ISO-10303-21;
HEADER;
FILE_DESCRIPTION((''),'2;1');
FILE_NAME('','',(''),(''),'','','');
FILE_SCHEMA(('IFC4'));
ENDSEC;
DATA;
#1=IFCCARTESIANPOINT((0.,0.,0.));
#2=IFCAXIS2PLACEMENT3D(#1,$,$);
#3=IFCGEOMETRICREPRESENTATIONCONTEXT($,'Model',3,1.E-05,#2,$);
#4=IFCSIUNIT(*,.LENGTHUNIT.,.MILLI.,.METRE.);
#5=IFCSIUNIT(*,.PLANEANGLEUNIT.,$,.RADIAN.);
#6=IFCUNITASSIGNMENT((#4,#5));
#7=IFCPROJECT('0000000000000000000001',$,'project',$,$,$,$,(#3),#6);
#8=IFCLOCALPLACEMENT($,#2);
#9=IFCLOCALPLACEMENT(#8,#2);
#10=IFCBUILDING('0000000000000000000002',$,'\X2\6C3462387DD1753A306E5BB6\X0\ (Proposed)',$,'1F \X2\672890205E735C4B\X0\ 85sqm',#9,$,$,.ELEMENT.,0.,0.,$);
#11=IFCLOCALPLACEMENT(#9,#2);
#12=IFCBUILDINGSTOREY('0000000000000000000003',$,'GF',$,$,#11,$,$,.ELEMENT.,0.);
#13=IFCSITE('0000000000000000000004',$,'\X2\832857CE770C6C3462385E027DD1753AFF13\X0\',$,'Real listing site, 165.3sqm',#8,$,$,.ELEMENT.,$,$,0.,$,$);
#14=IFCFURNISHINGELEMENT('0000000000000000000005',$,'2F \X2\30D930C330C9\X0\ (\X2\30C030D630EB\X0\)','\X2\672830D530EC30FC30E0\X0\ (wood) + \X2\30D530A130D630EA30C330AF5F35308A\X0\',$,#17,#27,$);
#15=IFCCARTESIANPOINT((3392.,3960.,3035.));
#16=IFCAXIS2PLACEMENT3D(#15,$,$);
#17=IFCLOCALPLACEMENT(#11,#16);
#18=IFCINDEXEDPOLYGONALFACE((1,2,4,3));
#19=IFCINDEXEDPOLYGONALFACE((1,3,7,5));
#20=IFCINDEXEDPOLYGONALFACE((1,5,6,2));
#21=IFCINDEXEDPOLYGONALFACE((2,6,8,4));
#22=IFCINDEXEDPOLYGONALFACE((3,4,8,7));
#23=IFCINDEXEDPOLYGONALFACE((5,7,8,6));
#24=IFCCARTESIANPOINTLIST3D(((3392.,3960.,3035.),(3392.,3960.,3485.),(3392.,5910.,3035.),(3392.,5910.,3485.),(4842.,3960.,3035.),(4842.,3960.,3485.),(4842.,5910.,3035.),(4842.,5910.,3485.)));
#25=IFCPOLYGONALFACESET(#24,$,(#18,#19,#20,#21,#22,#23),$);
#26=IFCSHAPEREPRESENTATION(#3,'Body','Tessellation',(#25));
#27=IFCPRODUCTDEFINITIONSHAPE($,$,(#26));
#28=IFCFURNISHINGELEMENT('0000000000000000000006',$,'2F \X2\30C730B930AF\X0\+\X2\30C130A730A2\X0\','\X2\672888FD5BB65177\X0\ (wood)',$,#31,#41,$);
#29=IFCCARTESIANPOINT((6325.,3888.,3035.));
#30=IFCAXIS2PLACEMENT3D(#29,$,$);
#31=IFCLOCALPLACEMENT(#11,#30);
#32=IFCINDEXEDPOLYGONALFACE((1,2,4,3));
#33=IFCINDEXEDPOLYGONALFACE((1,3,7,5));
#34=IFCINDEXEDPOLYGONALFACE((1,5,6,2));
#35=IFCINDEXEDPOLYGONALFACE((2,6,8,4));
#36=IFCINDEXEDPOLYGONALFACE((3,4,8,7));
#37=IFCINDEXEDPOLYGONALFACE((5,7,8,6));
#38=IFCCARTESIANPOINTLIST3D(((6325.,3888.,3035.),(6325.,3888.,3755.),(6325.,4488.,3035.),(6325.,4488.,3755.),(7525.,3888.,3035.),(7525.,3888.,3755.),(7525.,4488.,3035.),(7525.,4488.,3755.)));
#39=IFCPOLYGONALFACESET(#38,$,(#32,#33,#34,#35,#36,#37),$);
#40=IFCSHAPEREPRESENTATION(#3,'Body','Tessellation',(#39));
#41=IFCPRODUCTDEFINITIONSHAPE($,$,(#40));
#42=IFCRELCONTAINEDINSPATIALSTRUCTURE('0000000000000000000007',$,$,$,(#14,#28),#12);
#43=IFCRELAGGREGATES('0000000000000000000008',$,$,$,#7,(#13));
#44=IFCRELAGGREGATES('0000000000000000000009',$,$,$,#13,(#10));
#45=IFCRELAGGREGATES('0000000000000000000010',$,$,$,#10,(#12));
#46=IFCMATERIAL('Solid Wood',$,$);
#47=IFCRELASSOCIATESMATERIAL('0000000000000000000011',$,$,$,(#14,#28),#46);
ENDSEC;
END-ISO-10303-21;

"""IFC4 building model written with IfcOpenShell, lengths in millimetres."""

from ifc_helpers import new_model, si_unit, frame, frame_2d, origin, place, context, project, spatial, rectangle, extrude, material, element, save


model = new_model("IFC4")

# Units and contexts
model_context = context("Model", 3, precision=1e-05, world=origin())
ifc_project = project(units=[si_unit("LENGTHUNIT", "METRE", prefix="MILLI"), si_unit("PLANEANGLEUNIT", "RADIAN")], contexts=[model_context])

# Site, building, storey
site_placement = place(None, origin())
site = spatial("IfcSite", under=ifc_project, at=site_placement, Name="茨城県水戸市緑町３", ObjectType="Real listing site, 165.3sqm", CompositionType="ELEMENT", RefElevation=0.0)
building_placement = place(site_placement, origin())
building = spatial("IfcBuilding", under=site, at=building_placement, Name="水戸緑町の家 (Proposed)", ObjectType="1F 木造平屋 85sqm", CompositionType="ELEMENT", ElevationOfRefHeight=0.0, ElevationOfTerrain=0.0)
storey_placement = place(building_placement, origin())
storey = spatial("IfcBuildingStorey", under=building, at=storey_placement, Name="GF", CompositionType="ELEMENT", Elevation=0.0)

# Shared definitions
ifc_material_1 = material(Name="Solid Wood")

# Furnishing elements
furnishing_1_placement = place(storey_placement, frame((3392.0, 3960.0, 3035.0)))
element("IfcFurnishingElement", 1, at=furnishing_1_placement, inside=storey, material=ifc_material_1, Name="2F ベッド (ダブル)", Description="木フレーム (wood) + ファブリック張り", context=model_context, shape_type="SweptSolid", body=[
    extrude(rectangle(XDim=1450.0, YDim=1950.0, at=frame_2d((725.0, 975.0))), frame((3392.0, 3960.0, 3035.0)), (0.0, 0.0, 1.0), 450.0),
])
furnishing_2_placement = place(storey_placement, frame((6325.0, 3888.0, 3035.0)))
element("IfcFurnishingElement", 2, at=furnishing_2_placement, inside=storey, material=ifc_material_1, Name="2F デスク+チェア", Description="木製家具 (wood)", context=model_context, shape_type="SweptSolid", body=[
    extrude(rectangle(XDim=1200.0, YDim=600.0, at=frame_2d((600.0, 300.0))), frame((6325.0, 3888.0, 3035.0)), (0.0, 0.0, 1.0), 720.0),
])

save(model, "model.ifc")
